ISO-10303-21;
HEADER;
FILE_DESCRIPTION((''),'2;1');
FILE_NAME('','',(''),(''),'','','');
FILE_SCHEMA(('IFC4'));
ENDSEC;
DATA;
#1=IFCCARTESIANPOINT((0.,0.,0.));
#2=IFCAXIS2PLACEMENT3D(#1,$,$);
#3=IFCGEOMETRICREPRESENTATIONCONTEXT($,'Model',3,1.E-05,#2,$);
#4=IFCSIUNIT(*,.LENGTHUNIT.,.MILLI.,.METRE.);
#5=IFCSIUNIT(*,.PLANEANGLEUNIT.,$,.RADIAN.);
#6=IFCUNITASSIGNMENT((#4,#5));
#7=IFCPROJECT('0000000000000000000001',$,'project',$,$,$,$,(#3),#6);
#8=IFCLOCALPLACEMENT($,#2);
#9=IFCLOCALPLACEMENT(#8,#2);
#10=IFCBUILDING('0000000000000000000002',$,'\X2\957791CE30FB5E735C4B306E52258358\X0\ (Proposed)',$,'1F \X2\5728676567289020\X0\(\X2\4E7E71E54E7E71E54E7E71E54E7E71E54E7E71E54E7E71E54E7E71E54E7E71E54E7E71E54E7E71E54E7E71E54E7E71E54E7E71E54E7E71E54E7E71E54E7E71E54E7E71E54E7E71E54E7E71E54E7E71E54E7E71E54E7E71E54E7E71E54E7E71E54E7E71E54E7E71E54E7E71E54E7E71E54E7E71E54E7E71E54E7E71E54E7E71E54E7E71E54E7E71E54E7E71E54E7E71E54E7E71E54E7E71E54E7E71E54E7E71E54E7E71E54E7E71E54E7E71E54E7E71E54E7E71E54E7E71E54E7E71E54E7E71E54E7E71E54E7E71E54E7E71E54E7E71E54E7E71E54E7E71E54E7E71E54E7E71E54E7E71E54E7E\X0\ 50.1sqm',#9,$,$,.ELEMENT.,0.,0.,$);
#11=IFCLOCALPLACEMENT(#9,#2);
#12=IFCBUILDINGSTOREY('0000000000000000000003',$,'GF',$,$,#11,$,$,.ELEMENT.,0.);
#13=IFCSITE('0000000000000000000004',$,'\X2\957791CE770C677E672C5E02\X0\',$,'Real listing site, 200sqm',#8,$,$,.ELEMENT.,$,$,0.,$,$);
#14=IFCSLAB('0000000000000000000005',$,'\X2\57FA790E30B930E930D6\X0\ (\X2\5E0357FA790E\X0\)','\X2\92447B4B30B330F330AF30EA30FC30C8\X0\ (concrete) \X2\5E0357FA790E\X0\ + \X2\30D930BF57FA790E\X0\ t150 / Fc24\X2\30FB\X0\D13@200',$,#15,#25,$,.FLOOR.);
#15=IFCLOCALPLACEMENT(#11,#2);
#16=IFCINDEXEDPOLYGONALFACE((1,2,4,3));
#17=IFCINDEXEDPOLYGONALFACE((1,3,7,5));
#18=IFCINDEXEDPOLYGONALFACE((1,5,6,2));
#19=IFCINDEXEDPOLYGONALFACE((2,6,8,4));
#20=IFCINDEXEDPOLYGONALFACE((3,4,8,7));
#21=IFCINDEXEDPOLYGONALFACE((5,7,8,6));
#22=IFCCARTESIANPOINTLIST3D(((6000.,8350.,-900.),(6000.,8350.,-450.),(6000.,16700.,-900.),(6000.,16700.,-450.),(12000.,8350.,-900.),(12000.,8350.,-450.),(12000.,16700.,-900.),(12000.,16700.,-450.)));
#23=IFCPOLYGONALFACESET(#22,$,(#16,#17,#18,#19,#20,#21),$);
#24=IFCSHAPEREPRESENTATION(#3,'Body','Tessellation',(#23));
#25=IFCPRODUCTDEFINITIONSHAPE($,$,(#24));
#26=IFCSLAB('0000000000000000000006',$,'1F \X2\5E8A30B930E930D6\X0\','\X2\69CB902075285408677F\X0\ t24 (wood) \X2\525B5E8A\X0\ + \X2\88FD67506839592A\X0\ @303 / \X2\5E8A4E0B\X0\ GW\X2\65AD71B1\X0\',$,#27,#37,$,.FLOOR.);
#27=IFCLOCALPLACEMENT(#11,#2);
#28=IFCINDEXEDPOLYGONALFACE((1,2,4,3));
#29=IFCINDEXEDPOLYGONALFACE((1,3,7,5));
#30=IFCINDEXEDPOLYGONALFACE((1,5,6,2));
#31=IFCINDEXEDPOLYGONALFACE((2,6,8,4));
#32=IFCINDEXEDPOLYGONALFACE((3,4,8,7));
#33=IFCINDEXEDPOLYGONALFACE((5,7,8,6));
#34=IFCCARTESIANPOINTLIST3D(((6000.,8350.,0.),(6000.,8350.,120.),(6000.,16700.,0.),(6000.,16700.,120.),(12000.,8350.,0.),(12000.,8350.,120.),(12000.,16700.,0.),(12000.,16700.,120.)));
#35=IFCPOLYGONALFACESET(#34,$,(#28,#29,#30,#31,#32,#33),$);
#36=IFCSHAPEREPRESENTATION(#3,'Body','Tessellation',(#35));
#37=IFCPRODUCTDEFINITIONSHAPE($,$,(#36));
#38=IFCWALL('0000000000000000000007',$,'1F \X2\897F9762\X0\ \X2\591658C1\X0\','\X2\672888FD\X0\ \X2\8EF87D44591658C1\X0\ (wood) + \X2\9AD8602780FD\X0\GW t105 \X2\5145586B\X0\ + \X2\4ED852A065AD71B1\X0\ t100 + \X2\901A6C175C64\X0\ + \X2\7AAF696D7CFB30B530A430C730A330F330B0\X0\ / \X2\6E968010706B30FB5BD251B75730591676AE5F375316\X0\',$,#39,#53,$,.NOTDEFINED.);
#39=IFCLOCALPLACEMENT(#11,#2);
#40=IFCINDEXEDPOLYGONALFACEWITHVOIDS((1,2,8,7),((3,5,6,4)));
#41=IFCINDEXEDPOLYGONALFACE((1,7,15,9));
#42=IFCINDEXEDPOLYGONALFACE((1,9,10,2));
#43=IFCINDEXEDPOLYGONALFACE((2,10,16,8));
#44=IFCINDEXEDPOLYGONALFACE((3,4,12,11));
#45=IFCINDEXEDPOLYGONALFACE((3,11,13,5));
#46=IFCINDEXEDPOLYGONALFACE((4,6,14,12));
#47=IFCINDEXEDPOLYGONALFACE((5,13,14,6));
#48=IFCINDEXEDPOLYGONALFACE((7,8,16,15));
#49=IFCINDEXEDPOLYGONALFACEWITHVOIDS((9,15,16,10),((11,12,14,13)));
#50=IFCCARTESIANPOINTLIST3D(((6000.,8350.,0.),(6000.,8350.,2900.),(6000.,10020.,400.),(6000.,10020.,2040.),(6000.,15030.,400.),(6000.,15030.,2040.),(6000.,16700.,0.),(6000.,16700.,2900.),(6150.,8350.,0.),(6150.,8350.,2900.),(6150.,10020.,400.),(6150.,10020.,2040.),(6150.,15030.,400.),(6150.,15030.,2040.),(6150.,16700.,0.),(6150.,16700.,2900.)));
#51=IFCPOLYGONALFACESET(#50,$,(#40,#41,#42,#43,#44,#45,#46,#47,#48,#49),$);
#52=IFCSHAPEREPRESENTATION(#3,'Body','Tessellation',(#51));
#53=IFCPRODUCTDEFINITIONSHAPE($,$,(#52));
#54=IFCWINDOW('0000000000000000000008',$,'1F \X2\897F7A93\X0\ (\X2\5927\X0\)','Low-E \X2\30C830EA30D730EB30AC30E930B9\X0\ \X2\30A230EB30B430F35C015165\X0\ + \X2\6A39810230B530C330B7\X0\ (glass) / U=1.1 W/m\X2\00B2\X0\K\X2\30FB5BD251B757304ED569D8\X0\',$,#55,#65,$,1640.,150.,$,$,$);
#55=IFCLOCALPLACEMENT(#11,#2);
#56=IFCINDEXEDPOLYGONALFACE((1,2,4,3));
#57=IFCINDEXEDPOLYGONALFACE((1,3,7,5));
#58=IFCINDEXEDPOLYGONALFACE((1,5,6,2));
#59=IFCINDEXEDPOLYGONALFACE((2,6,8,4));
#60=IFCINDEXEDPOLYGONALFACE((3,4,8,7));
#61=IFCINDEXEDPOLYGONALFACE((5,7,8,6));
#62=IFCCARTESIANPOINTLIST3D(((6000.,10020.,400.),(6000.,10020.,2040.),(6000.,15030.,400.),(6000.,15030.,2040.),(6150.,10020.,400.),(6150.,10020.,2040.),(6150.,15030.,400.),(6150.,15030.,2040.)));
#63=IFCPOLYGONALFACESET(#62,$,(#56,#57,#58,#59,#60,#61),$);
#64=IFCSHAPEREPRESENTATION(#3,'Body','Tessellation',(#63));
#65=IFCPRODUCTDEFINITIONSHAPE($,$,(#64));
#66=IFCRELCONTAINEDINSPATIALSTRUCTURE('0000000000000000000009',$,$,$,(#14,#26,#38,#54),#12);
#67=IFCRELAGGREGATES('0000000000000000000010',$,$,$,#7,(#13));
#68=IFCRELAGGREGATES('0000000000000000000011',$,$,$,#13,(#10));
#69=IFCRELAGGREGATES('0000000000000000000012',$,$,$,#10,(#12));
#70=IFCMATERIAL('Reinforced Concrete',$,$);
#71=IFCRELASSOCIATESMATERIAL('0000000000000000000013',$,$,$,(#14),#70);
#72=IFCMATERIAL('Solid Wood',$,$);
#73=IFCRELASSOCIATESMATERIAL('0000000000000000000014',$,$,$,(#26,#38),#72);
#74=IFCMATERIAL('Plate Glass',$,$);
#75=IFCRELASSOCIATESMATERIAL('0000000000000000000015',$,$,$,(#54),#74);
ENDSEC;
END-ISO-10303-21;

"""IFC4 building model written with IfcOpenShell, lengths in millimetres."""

from ifc_helpers import new_model, si_unit, frame, frame_2d, origin, place, context, project, spatial, rectangle, extrude, material, element, fill, save


model = new_model("IFC4")

# Units and contexts
model_context = context("Model", 3, precision=1e-05, world=origin())
ifc_project = project(units=[si_unit("LENGTHUNIT", "METRE", prefix="MILLI"), si_unit("PLANEANGLEUNIT", "RADIAN")], contexts=[model_context])

# Site, building, storey
site_placement = place(None, origin())
site = spatial("IfcSite", under=ifc_project, at=site_placement, Name="長野県松本市", ObjectType="Real listing site, 200sqm", CompositionType="ELEMENT", RefElevation=0.0)
building_placement = place(site_placement, origin())
building = spatial("IfcBuilding", under=site, at=building_placement, Name="長野・平屋の別荘 (Proposed)", ObjectType="1F 在来木造(乾燥乾燥乾燥乾燥乾燥乾燥乾燥乾燥乾燥乾燥乾燥乾燥乾燥乾燥乾燥乾燥乾燥乾燥乾燥乾燥乾燥乾燥乾燥乾燥乾燥乾燥乾燥乾燥乾燥乾燥乾燥乾燥乾燥乾燥乾燥乾燥乾燥乾燥乾燥乾燥乾燥乾燥乾燥乾燥乾燥乾燥乾燥乾燥乾燥乾燥乾燥乾燥乾燥乾燥乾燥乾燥乾燥乾 50.1sqm", CompositionType="ELEMENT", ElevationOfRefHeight=0.0, ElevationOfTerrain=0.0)
storey_placement = place(building_placement, origin())
storey = spatial("IfcBuildingStorey", under=building, at=storey_placement, Name="GF", CompositionType="ELEMENT", Elevation=0.0)

# Shared definitions
ifc_material_1 = material(Name="Solid Wood")

# Slabs
ifc_material_2 = material(Name="Reinforced Concrete")
slab_1_placement = place(storey_placement, frame((3000.0, 4175.0, -450.0)))
element("IfcSlab", 1, at=slab_1_placement, inside=storey, material=ifc_material_2, Name="基礎スラブ (布基礎)", Description="鉄筋コンクリート (concrete) 布基礎 + ベタ基礎 t150 / Fc24・D13@200", PredefinedType="FLOOR", context=model_context, shape_type="SweptSolid", body=[
    extrude(rectangle(XDim=6000.0, YDim=8350.0, at=frame_2d((3000.0, 4175.0))), frame((3000.0, 4175.0, -450.0)), (0.0, 0.0, 1.0), 450.0),
])
slab_2_placement = place(storey_placement, frame((3000.0, 4175.0, 0.0)))
element("IfcSlab", 2, at=slab_2_placement, inside=storey, material=ifc_material_1, Name="1F 床スラブ", Description="構造用合板 t24 (wood) 剛床 + 製材根太 @303 / 床下 GW断熱", PredefinedType="FLOOR", context=model_context, shape_type="SweptSolid", body=[
    extrude(rectangle(XDim=6000.0, YDim=8350.0, at=frame_2d((3000.0, 4175.0))), frame((3000.0, 4175.0, 0.0)), (0.0, 0.0, 1.0), 120.0),
])

# Shared definitions
ifc_material_3 = material(Name="Plate Glass")

# Wall, opening, window
wall_1_placement = place(storey_placement, frame((3000.0, 4175.0, 0.0)))
wall_1 = element("IfcWall", 3, at=wall_1_placement, inside=storey, material=ifc_material_1, Name="1F 西面 外壁", Description="木製 軸組外壁 (wood) + 高性能GW t105 充填 + 付加断熱 t100 + 通気層 + 窯業系サイディング / 準耐火・寒冷地外皮強化", PredefinedType="NOTDEFINED", context=model_context, shape_type="SweptSolid", body=[
    extrude(rectangle(XDim=150.0, YDim=8350.0, at=frame_2d((75.0, 4175.0))), frame((3000.0, 4175.0, 0.0)), (0.0, 0.0, 1.0), 2900.0),
])
opening_1_placement = place(storey_placement, frame((3000.0, 5010.0, 200.0)))
opening_1 = element("IfcOpeningElement", 4, at=opening_1_placement, cuts=wall_1, PredefinedType="NOTDEFINED", context=model_context, shape_type="SweptSolid", body=[
    extrude(rectangle(XDim=150.0, YDim=5010.0, at=frame_2d((75.0, 2505.0))), frame((3000.0, 5010.0, 200.0)), (0.0, 0.0, 1.0), 1640.0),
])
window_1_placement = place(storey_placement, frame((3000.0, 5010.0, 200.0)))
window_1 = element("IfcWindow", 5, at=window_1_placement, inside=storey, material=ifc_material_3, Name="1F 西窓 (大)", Description="Low-E トリプルガラス アルゴン封入 + 樹脂サッシ (glass) / U=1.1 W/m²K・寒冷地仕様", OverallHeight=1640.0, OverallWidth=150.0, context=model_context, shape_type="SweptSolid", body=[
    extrude(rectangle(XDim=150.0, YDim=5010.0, at=frame_2d((75.0, 2505.0))), frame((3000.0, 5010.0, 200.0)), (0.0, 0.0, 1.0), 1640.0),
])
fill(opening_1, window_1)

save(model, "model.ifc")
